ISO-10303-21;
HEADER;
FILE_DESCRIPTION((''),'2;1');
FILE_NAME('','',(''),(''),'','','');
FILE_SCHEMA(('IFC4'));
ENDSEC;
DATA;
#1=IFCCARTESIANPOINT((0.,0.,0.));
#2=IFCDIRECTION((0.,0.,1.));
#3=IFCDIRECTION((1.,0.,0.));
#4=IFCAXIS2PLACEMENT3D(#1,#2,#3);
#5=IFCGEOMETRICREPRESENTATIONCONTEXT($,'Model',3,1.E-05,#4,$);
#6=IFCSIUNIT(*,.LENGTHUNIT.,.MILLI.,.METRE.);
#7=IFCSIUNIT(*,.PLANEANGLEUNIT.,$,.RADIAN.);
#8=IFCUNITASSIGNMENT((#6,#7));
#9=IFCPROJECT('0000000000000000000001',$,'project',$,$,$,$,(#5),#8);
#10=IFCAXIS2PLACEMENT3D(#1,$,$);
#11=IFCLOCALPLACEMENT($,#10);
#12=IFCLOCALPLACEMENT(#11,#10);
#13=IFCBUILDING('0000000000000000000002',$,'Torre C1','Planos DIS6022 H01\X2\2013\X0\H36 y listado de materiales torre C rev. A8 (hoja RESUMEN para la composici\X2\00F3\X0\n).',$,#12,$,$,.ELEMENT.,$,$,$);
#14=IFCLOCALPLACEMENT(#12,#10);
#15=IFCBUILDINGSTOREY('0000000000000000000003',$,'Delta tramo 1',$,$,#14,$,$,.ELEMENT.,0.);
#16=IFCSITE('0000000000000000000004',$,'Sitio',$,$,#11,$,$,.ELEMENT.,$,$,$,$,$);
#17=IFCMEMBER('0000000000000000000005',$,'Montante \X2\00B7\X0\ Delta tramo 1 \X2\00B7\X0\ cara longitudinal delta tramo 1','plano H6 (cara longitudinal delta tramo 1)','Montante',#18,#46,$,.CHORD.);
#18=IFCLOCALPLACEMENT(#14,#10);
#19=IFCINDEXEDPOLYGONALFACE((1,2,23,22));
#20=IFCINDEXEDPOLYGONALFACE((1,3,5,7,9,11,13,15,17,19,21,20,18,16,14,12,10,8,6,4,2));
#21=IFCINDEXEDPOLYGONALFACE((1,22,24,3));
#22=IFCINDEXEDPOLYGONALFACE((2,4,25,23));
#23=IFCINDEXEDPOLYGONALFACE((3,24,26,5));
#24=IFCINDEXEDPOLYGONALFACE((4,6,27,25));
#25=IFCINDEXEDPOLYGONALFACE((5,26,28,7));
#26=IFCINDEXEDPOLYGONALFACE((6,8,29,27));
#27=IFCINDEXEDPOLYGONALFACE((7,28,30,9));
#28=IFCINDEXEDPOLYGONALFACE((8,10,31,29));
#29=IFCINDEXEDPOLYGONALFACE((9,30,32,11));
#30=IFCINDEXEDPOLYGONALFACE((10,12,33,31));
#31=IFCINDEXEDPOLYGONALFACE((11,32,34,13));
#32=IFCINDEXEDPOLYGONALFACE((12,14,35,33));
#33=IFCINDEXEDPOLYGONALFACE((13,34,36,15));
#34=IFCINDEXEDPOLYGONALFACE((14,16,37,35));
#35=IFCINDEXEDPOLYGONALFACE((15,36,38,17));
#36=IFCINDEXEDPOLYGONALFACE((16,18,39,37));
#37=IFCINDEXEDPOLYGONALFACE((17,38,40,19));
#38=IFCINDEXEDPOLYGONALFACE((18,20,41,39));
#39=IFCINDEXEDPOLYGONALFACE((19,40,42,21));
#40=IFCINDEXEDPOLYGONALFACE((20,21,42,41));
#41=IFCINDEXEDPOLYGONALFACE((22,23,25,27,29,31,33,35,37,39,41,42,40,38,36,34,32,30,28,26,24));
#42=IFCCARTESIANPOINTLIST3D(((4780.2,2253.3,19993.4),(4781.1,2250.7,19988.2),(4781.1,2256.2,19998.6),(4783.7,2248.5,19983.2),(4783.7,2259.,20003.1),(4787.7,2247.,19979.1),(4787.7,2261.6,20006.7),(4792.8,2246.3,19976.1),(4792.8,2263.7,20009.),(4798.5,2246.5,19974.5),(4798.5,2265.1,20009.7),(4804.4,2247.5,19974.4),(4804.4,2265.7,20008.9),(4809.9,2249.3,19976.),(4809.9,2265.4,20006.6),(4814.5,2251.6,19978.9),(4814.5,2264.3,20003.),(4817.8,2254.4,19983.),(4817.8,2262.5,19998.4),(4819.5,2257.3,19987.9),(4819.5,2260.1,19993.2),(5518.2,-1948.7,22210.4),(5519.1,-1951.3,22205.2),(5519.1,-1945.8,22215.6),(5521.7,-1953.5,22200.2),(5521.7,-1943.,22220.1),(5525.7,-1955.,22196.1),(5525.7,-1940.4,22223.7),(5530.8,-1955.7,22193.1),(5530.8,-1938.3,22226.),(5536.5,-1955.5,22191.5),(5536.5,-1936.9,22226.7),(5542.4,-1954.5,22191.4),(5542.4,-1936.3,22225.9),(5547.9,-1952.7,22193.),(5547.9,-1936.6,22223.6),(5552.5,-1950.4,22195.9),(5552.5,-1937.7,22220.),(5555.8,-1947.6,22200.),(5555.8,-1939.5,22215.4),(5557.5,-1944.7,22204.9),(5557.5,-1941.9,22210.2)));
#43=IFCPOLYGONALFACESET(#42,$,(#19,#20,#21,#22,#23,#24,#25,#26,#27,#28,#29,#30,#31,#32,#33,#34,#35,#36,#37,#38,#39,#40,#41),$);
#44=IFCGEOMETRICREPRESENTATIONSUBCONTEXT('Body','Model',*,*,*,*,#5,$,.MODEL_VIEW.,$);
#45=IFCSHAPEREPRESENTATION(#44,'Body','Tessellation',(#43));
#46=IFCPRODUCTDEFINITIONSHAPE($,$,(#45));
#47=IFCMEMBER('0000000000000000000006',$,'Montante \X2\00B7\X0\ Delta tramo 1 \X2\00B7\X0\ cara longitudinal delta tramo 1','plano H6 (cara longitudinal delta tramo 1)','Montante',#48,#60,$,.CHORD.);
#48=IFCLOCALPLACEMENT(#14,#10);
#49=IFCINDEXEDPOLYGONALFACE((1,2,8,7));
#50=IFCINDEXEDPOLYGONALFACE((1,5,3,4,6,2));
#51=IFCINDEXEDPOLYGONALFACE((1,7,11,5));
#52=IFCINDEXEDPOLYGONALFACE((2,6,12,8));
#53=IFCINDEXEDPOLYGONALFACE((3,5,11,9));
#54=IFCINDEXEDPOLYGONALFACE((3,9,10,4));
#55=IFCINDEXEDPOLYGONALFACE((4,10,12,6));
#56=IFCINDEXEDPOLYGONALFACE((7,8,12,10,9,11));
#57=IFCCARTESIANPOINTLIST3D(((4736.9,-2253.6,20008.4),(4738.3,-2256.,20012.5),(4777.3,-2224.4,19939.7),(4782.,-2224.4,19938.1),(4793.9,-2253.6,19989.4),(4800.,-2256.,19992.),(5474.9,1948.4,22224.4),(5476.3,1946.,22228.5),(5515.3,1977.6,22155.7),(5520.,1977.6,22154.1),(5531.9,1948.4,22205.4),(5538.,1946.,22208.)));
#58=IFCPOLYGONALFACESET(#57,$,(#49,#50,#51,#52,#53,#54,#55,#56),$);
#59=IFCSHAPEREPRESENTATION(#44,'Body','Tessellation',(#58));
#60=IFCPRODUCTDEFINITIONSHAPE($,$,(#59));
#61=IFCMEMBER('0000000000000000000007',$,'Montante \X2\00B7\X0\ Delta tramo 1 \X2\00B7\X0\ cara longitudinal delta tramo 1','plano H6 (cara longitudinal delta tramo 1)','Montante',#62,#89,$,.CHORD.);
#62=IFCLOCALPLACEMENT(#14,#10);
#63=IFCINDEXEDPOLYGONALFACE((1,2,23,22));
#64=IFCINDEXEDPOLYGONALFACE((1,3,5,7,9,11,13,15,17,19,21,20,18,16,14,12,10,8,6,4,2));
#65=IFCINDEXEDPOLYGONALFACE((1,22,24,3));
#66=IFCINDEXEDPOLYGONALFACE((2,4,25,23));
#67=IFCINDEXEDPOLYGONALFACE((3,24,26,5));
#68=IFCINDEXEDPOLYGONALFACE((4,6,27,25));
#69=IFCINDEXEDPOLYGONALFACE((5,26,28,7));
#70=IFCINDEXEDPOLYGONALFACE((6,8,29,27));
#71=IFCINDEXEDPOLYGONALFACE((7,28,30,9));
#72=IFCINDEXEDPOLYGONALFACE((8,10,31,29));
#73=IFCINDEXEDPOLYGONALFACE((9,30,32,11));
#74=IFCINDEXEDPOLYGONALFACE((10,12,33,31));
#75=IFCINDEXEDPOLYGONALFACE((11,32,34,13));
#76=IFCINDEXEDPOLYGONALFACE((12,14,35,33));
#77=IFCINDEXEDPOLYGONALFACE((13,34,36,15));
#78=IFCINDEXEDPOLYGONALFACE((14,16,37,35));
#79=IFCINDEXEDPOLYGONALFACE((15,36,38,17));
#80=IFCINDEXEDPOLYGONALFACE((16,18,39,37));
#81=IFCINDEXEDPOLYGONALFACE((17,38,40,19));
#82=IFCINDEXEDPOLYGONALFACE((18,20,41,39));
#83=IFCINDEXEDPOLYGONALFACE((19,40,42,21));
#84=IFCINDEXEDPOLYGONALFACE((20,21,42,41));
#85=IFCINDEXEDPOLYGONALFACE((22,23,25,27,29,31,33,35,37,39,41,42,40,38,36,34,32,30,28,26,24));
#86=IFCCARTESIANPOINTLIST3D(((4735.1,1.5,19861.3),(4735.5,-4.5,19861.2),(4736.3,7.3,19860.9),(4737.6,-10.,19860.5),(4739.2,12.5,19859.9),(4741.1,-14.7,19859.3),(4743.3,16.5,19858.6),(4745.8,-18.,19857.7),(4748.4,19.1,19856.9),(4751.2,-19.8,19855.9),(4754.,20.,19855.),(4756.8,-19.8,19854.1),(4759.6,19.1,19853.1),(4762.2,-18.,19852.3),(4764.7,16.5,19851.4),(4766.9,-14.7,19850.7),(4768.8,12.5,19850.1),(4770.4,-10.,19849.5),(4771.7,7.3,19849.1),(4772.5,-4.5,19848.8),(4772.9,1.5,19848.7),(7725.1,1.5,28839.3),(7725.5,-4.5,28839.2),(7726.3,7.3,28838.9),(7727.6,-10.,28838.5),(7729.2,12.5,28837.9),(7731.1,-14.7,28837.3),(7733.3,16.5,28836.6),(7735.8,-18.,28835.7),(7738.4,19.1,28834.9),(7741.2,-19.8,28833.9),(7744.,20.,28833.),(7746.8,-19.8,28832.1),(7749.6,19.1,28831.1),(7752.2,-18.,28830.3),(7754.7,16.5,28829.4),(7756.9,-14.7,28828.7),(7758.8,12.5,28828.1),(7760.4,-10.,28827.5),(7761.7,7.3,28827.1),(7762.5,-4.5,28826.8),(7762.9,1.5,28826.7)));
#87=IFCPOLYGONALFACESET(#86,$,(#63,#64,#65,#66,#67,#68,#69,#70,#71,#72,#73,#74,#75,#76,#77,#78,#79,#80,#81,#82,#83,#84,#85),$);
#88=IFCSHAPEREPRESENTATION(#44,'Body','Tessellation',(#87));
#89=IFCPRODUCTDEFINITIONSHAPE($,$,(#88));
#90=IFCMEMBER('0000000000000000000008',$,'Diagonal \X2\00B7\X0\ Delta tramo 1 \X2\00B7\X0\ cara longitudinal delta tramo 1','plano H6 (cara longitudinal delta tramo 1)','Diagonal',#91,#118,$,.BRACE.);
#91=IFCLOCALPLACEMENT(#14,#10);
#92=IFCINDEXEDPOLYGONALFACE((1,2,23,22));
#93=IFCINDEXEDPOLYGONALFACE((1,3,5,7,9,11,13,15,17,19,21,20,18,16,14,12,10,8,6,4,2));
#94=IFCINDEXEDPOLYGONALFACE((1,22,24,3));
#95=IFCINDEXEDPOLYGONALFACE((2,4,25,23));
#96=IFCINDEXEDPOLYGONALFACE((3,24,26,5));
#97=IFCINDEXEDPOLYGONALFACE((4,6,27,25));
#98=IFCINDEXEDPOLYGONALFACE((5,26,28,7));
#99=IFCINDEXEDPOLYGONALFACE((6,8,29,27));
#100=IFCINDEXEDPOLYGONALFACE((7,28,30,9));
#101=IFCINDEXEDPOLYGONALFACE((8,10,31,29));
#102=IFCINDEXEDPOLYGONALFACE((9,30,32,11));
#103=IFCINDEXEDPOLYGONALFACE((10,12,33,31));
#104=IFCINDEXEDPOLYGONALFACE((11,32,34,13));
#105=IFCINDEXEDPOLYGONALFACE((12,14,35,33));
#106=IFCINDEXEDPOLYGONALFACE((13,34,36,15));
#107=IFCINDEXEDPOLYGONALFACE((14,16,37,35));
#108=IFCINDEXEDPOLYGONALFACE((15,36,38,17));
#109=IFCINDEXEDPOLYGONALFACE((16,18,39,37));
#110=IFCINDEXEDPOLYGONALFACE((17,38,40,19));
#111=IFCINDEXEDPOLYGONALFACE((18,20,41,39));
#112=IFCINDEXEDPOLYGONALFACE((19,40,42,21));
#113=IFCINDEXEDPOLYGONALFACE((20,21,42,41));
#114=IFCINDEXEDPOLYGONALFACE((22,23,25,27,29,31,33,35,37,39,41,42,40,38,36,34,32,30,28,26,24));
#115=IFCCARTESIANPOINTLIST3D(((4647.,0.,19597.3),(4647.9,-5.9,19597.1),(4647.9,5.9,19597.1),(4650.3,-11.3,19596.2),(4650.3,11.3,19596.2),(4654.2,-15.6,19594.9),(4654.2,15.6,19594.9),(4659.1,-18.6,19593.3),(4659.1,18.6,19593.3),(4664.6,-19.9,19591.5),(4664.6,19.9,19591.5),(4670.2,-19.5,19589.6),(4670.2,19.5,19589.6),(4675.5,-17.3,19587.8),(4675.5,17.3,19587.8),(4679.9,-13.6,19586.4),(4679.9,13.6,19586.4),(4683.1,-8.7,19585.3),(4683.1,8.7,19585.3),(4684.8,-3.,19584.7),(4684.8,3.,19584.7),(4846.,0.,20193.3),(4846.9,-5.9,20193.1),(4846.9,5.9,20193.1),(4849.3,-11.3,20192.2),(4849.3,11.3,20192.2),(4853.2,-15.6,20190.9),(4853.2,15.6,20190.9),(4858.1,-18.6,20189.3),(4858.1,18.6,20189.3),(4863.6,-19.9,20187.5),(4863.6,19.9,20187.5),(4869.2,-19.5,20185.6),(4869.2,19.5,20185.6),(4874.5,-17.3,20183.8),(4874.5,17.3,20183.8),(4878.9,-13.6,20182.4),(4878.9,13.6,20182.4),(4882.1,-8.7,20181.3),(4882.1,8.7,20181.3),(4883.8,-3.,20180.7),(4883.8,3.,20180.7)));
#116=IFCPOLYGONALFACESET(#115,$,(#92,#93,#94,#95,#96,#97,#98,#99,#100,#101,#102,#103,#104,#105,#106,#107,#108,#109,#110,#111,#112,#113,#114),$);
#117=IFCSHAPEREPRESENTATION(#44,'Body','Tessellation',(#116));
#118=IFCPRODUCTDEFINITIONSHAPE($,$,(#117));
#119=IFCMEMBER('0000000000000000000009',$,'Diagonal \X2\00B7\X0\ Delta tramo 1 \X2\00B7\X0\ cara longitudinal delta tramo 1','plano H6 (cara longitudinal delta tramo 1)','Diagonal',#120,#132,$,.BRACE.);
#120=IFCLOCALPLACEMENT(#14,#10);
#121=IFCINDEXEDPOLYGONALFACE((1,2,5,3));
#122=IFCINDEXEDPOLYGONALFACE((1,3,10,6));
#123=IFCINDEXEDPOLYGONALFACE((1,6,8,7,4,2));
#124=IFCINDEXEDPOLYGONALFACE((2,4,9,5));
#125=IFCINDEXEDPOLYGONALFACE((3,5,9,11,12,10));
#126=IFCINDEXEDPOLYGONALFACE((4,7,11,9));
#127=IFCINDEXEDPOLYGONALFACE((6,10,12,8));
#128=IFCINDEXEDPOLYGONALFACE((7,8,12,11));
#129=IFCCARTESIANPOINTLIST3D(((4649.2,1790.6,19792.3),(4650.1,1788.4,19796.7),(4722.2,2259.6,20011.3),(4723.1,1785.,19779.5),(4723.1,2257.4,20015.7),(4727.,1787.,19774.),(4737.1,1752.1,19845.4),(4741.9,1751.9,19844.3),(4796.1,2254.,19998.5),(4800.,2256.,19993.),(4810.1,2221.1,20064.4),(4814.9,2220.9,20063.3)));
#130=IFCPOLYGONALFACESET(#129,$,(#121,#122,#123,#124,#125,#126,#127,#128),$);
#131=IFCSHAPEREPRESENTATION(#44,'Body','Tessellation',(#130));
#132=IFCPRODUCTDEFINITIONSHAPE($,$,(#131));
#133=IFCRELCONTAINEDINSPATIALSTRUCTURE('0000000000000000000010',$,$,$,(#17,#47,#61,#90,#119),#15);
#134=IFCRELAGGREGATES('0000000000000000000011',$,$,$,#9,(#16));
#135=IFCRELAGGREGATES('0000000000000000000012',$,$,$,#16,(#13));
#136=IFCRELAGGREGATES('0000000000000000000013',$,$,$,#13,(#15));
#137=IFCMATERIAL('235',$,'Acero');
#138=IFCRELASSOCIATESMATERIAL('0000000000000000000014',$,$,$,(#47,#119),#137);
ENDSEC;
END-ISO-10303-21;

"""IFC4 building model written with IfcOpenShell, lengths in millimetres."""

from ifc_helpers import new_model, si_unit, frame, frame_2d, origin, origin_with_axes, place, context, subcontext, project, spatial, circle, l_section, extrude, material, element, save


model = new_model("IFC4")

# Units and contexts
model_context = context("Model", 3, precision=1e-05, world=origin_with_axes())
body_context = subcontext(model_context, "Body", "Model", "MODEL_VIEW")
ifc_project = project(units=[si_unit("LENGTHUNIT", "METRE", prefix="MILLI"), si_unit("PLANEANGLEUNIT", "RADIAN")], contexts=[model_context])

# Site, building, storey
site_placement = place(None, origin())
site = spatial("IfcSite", under=ifc_project, at=site_placement, Name="Sitio", CompositionType="ELEMENT")
building_placement = place(site_placement, origin())
building = spatial("IfcBuilding", under=site, at=building_placement, Name="Torre C1", Description="Planos DIS6022 H01–H36 y listado de materiales torre C rev. A8 (hoja RESUMEN para la composición).", CompositionType="ELEMENT")
storey_placement = place(building_placement, origin())
storey = spatial("IfcBuildingStorey", under=building, at=storey_placement, Name="Delta tramo 1", CompositionType="ELEMENT", Elevation=0.0)

# Members
member_1_placement = place(storey_placement, frame((4800.0, 2256.0, 19992.0), z_axis=(0.153495, -0.873966, 0.46111), x_axis=(-0.988149, -0.135759, 0.071627)))
element("IfcMember", 1, at=member_1_placement, inside=storey, Name="Montante · Delta tramo 1 · cara longitudinal delta tramo 1", Description="plano H6 (cara longitudinal delta tramo 1)", ObjectType="Montante", PredefinedType="CHORD", context=body_context, shape_type="SweptSolid", body=[
    extrude(circle(Radius=20.0), None, (0.0, 0.0, 1.0), 4808.0),
])
ifc_material_1 = material(Name="235", Category="Acero")
member_2_placement = place(storey_placement, frame((4800.0, -2256.0, 19992.0), z_axis=(0.15351, 0.87405, 0.460946), x_axis=(-0.276174, 0.485836, -0.829272)))
element("IfcMember", 2, at=member_2_placement, inside=storey, material=ifc_material_1, Name="Montante · Delta tramo 1 · cara longitudinal delta tramo 1", Description="plano H6 (cara longitudinal delta tramo 1)", ObjectType="Montante", PredefinedType="CHORD", context=body_context, shape_type="SweptSolid", body=[
    extrude(l_section(Depth=65.0, Width=65.0, Thickness=5.0, at=frame_2d((32.5, 32.5))), None, (0.0, 0.0, 1.0), 4807.5),
])
member_3_placement = place(storey_placement, frame((4754.0, 0.0, 19855.0), z_axis=(0.315974, 0.0, 0.948768), x_axis=(0.0, 1.0, 0.0)))
element("IfcMember", 3, at=member_3_placement, inside=storey, Name="Montante · Delta tramo 1 · cara longitudinal delta tramo 1", Description="plano H6 (cara longitudinal delta tramo 1)", ObjectType="Montante", PredefinedType="CHORD", context=body_context, shape_type="SweptSolid", body=[
    extrude(circle(Radius=20.0), None, (0.0, 0.0, 1.0), 9462.8),
])
member_4_placement = place(storey_placement, frame((4666.0, 0.0, 19591.0), z_axis=(0.316705, 0.0, 0.948524), x_axis=(-0.948524, 0.0, 0.316705)))
element("IfcMember", 4, at=member_4_placement, inside=storey, Name="Diagonal · Delta tramo 1 · cara longitudinal delta tramo 1", Description="plano H6 (cara longitudinal delta tramo 1)", ObjectType="Diagonal", PredefinedType="BRACE", context=body_context, shape_type="SweptSolid", body=[
    extrude(circle(Radius=20.0), None, (0.0, 0.0, 1.0), 628.3),
])
member_5_placement = place(storey_placement, frame((4727.0, 1787.0, 19774.0), z_axis=(0.13965, 0.897206, 0.418951), x_axis=(-0.972489, 0.044604, 0.22864)))
element("IfcMember", 5, at=member_5_placement, inside=storey, material=ifc_material_1, Name="Diagonal · Delta tramo 1 · cara longitudinal delta tramo 1", Description="plano H6 (cara longitudinal delta tramo 1)", ObjectType="Diagonal", PredefinedType="BRACE", context=body_context, shape_type="SweptSolid", body=[
    extrude(l_section(Depth=80.0, Width=80.0, Thickness=5.0, at=frame_2d((40.0, 40.0))), None, (0.0, 0.0, 1.0), 522.7),
])

save(model, "model.ifc")
